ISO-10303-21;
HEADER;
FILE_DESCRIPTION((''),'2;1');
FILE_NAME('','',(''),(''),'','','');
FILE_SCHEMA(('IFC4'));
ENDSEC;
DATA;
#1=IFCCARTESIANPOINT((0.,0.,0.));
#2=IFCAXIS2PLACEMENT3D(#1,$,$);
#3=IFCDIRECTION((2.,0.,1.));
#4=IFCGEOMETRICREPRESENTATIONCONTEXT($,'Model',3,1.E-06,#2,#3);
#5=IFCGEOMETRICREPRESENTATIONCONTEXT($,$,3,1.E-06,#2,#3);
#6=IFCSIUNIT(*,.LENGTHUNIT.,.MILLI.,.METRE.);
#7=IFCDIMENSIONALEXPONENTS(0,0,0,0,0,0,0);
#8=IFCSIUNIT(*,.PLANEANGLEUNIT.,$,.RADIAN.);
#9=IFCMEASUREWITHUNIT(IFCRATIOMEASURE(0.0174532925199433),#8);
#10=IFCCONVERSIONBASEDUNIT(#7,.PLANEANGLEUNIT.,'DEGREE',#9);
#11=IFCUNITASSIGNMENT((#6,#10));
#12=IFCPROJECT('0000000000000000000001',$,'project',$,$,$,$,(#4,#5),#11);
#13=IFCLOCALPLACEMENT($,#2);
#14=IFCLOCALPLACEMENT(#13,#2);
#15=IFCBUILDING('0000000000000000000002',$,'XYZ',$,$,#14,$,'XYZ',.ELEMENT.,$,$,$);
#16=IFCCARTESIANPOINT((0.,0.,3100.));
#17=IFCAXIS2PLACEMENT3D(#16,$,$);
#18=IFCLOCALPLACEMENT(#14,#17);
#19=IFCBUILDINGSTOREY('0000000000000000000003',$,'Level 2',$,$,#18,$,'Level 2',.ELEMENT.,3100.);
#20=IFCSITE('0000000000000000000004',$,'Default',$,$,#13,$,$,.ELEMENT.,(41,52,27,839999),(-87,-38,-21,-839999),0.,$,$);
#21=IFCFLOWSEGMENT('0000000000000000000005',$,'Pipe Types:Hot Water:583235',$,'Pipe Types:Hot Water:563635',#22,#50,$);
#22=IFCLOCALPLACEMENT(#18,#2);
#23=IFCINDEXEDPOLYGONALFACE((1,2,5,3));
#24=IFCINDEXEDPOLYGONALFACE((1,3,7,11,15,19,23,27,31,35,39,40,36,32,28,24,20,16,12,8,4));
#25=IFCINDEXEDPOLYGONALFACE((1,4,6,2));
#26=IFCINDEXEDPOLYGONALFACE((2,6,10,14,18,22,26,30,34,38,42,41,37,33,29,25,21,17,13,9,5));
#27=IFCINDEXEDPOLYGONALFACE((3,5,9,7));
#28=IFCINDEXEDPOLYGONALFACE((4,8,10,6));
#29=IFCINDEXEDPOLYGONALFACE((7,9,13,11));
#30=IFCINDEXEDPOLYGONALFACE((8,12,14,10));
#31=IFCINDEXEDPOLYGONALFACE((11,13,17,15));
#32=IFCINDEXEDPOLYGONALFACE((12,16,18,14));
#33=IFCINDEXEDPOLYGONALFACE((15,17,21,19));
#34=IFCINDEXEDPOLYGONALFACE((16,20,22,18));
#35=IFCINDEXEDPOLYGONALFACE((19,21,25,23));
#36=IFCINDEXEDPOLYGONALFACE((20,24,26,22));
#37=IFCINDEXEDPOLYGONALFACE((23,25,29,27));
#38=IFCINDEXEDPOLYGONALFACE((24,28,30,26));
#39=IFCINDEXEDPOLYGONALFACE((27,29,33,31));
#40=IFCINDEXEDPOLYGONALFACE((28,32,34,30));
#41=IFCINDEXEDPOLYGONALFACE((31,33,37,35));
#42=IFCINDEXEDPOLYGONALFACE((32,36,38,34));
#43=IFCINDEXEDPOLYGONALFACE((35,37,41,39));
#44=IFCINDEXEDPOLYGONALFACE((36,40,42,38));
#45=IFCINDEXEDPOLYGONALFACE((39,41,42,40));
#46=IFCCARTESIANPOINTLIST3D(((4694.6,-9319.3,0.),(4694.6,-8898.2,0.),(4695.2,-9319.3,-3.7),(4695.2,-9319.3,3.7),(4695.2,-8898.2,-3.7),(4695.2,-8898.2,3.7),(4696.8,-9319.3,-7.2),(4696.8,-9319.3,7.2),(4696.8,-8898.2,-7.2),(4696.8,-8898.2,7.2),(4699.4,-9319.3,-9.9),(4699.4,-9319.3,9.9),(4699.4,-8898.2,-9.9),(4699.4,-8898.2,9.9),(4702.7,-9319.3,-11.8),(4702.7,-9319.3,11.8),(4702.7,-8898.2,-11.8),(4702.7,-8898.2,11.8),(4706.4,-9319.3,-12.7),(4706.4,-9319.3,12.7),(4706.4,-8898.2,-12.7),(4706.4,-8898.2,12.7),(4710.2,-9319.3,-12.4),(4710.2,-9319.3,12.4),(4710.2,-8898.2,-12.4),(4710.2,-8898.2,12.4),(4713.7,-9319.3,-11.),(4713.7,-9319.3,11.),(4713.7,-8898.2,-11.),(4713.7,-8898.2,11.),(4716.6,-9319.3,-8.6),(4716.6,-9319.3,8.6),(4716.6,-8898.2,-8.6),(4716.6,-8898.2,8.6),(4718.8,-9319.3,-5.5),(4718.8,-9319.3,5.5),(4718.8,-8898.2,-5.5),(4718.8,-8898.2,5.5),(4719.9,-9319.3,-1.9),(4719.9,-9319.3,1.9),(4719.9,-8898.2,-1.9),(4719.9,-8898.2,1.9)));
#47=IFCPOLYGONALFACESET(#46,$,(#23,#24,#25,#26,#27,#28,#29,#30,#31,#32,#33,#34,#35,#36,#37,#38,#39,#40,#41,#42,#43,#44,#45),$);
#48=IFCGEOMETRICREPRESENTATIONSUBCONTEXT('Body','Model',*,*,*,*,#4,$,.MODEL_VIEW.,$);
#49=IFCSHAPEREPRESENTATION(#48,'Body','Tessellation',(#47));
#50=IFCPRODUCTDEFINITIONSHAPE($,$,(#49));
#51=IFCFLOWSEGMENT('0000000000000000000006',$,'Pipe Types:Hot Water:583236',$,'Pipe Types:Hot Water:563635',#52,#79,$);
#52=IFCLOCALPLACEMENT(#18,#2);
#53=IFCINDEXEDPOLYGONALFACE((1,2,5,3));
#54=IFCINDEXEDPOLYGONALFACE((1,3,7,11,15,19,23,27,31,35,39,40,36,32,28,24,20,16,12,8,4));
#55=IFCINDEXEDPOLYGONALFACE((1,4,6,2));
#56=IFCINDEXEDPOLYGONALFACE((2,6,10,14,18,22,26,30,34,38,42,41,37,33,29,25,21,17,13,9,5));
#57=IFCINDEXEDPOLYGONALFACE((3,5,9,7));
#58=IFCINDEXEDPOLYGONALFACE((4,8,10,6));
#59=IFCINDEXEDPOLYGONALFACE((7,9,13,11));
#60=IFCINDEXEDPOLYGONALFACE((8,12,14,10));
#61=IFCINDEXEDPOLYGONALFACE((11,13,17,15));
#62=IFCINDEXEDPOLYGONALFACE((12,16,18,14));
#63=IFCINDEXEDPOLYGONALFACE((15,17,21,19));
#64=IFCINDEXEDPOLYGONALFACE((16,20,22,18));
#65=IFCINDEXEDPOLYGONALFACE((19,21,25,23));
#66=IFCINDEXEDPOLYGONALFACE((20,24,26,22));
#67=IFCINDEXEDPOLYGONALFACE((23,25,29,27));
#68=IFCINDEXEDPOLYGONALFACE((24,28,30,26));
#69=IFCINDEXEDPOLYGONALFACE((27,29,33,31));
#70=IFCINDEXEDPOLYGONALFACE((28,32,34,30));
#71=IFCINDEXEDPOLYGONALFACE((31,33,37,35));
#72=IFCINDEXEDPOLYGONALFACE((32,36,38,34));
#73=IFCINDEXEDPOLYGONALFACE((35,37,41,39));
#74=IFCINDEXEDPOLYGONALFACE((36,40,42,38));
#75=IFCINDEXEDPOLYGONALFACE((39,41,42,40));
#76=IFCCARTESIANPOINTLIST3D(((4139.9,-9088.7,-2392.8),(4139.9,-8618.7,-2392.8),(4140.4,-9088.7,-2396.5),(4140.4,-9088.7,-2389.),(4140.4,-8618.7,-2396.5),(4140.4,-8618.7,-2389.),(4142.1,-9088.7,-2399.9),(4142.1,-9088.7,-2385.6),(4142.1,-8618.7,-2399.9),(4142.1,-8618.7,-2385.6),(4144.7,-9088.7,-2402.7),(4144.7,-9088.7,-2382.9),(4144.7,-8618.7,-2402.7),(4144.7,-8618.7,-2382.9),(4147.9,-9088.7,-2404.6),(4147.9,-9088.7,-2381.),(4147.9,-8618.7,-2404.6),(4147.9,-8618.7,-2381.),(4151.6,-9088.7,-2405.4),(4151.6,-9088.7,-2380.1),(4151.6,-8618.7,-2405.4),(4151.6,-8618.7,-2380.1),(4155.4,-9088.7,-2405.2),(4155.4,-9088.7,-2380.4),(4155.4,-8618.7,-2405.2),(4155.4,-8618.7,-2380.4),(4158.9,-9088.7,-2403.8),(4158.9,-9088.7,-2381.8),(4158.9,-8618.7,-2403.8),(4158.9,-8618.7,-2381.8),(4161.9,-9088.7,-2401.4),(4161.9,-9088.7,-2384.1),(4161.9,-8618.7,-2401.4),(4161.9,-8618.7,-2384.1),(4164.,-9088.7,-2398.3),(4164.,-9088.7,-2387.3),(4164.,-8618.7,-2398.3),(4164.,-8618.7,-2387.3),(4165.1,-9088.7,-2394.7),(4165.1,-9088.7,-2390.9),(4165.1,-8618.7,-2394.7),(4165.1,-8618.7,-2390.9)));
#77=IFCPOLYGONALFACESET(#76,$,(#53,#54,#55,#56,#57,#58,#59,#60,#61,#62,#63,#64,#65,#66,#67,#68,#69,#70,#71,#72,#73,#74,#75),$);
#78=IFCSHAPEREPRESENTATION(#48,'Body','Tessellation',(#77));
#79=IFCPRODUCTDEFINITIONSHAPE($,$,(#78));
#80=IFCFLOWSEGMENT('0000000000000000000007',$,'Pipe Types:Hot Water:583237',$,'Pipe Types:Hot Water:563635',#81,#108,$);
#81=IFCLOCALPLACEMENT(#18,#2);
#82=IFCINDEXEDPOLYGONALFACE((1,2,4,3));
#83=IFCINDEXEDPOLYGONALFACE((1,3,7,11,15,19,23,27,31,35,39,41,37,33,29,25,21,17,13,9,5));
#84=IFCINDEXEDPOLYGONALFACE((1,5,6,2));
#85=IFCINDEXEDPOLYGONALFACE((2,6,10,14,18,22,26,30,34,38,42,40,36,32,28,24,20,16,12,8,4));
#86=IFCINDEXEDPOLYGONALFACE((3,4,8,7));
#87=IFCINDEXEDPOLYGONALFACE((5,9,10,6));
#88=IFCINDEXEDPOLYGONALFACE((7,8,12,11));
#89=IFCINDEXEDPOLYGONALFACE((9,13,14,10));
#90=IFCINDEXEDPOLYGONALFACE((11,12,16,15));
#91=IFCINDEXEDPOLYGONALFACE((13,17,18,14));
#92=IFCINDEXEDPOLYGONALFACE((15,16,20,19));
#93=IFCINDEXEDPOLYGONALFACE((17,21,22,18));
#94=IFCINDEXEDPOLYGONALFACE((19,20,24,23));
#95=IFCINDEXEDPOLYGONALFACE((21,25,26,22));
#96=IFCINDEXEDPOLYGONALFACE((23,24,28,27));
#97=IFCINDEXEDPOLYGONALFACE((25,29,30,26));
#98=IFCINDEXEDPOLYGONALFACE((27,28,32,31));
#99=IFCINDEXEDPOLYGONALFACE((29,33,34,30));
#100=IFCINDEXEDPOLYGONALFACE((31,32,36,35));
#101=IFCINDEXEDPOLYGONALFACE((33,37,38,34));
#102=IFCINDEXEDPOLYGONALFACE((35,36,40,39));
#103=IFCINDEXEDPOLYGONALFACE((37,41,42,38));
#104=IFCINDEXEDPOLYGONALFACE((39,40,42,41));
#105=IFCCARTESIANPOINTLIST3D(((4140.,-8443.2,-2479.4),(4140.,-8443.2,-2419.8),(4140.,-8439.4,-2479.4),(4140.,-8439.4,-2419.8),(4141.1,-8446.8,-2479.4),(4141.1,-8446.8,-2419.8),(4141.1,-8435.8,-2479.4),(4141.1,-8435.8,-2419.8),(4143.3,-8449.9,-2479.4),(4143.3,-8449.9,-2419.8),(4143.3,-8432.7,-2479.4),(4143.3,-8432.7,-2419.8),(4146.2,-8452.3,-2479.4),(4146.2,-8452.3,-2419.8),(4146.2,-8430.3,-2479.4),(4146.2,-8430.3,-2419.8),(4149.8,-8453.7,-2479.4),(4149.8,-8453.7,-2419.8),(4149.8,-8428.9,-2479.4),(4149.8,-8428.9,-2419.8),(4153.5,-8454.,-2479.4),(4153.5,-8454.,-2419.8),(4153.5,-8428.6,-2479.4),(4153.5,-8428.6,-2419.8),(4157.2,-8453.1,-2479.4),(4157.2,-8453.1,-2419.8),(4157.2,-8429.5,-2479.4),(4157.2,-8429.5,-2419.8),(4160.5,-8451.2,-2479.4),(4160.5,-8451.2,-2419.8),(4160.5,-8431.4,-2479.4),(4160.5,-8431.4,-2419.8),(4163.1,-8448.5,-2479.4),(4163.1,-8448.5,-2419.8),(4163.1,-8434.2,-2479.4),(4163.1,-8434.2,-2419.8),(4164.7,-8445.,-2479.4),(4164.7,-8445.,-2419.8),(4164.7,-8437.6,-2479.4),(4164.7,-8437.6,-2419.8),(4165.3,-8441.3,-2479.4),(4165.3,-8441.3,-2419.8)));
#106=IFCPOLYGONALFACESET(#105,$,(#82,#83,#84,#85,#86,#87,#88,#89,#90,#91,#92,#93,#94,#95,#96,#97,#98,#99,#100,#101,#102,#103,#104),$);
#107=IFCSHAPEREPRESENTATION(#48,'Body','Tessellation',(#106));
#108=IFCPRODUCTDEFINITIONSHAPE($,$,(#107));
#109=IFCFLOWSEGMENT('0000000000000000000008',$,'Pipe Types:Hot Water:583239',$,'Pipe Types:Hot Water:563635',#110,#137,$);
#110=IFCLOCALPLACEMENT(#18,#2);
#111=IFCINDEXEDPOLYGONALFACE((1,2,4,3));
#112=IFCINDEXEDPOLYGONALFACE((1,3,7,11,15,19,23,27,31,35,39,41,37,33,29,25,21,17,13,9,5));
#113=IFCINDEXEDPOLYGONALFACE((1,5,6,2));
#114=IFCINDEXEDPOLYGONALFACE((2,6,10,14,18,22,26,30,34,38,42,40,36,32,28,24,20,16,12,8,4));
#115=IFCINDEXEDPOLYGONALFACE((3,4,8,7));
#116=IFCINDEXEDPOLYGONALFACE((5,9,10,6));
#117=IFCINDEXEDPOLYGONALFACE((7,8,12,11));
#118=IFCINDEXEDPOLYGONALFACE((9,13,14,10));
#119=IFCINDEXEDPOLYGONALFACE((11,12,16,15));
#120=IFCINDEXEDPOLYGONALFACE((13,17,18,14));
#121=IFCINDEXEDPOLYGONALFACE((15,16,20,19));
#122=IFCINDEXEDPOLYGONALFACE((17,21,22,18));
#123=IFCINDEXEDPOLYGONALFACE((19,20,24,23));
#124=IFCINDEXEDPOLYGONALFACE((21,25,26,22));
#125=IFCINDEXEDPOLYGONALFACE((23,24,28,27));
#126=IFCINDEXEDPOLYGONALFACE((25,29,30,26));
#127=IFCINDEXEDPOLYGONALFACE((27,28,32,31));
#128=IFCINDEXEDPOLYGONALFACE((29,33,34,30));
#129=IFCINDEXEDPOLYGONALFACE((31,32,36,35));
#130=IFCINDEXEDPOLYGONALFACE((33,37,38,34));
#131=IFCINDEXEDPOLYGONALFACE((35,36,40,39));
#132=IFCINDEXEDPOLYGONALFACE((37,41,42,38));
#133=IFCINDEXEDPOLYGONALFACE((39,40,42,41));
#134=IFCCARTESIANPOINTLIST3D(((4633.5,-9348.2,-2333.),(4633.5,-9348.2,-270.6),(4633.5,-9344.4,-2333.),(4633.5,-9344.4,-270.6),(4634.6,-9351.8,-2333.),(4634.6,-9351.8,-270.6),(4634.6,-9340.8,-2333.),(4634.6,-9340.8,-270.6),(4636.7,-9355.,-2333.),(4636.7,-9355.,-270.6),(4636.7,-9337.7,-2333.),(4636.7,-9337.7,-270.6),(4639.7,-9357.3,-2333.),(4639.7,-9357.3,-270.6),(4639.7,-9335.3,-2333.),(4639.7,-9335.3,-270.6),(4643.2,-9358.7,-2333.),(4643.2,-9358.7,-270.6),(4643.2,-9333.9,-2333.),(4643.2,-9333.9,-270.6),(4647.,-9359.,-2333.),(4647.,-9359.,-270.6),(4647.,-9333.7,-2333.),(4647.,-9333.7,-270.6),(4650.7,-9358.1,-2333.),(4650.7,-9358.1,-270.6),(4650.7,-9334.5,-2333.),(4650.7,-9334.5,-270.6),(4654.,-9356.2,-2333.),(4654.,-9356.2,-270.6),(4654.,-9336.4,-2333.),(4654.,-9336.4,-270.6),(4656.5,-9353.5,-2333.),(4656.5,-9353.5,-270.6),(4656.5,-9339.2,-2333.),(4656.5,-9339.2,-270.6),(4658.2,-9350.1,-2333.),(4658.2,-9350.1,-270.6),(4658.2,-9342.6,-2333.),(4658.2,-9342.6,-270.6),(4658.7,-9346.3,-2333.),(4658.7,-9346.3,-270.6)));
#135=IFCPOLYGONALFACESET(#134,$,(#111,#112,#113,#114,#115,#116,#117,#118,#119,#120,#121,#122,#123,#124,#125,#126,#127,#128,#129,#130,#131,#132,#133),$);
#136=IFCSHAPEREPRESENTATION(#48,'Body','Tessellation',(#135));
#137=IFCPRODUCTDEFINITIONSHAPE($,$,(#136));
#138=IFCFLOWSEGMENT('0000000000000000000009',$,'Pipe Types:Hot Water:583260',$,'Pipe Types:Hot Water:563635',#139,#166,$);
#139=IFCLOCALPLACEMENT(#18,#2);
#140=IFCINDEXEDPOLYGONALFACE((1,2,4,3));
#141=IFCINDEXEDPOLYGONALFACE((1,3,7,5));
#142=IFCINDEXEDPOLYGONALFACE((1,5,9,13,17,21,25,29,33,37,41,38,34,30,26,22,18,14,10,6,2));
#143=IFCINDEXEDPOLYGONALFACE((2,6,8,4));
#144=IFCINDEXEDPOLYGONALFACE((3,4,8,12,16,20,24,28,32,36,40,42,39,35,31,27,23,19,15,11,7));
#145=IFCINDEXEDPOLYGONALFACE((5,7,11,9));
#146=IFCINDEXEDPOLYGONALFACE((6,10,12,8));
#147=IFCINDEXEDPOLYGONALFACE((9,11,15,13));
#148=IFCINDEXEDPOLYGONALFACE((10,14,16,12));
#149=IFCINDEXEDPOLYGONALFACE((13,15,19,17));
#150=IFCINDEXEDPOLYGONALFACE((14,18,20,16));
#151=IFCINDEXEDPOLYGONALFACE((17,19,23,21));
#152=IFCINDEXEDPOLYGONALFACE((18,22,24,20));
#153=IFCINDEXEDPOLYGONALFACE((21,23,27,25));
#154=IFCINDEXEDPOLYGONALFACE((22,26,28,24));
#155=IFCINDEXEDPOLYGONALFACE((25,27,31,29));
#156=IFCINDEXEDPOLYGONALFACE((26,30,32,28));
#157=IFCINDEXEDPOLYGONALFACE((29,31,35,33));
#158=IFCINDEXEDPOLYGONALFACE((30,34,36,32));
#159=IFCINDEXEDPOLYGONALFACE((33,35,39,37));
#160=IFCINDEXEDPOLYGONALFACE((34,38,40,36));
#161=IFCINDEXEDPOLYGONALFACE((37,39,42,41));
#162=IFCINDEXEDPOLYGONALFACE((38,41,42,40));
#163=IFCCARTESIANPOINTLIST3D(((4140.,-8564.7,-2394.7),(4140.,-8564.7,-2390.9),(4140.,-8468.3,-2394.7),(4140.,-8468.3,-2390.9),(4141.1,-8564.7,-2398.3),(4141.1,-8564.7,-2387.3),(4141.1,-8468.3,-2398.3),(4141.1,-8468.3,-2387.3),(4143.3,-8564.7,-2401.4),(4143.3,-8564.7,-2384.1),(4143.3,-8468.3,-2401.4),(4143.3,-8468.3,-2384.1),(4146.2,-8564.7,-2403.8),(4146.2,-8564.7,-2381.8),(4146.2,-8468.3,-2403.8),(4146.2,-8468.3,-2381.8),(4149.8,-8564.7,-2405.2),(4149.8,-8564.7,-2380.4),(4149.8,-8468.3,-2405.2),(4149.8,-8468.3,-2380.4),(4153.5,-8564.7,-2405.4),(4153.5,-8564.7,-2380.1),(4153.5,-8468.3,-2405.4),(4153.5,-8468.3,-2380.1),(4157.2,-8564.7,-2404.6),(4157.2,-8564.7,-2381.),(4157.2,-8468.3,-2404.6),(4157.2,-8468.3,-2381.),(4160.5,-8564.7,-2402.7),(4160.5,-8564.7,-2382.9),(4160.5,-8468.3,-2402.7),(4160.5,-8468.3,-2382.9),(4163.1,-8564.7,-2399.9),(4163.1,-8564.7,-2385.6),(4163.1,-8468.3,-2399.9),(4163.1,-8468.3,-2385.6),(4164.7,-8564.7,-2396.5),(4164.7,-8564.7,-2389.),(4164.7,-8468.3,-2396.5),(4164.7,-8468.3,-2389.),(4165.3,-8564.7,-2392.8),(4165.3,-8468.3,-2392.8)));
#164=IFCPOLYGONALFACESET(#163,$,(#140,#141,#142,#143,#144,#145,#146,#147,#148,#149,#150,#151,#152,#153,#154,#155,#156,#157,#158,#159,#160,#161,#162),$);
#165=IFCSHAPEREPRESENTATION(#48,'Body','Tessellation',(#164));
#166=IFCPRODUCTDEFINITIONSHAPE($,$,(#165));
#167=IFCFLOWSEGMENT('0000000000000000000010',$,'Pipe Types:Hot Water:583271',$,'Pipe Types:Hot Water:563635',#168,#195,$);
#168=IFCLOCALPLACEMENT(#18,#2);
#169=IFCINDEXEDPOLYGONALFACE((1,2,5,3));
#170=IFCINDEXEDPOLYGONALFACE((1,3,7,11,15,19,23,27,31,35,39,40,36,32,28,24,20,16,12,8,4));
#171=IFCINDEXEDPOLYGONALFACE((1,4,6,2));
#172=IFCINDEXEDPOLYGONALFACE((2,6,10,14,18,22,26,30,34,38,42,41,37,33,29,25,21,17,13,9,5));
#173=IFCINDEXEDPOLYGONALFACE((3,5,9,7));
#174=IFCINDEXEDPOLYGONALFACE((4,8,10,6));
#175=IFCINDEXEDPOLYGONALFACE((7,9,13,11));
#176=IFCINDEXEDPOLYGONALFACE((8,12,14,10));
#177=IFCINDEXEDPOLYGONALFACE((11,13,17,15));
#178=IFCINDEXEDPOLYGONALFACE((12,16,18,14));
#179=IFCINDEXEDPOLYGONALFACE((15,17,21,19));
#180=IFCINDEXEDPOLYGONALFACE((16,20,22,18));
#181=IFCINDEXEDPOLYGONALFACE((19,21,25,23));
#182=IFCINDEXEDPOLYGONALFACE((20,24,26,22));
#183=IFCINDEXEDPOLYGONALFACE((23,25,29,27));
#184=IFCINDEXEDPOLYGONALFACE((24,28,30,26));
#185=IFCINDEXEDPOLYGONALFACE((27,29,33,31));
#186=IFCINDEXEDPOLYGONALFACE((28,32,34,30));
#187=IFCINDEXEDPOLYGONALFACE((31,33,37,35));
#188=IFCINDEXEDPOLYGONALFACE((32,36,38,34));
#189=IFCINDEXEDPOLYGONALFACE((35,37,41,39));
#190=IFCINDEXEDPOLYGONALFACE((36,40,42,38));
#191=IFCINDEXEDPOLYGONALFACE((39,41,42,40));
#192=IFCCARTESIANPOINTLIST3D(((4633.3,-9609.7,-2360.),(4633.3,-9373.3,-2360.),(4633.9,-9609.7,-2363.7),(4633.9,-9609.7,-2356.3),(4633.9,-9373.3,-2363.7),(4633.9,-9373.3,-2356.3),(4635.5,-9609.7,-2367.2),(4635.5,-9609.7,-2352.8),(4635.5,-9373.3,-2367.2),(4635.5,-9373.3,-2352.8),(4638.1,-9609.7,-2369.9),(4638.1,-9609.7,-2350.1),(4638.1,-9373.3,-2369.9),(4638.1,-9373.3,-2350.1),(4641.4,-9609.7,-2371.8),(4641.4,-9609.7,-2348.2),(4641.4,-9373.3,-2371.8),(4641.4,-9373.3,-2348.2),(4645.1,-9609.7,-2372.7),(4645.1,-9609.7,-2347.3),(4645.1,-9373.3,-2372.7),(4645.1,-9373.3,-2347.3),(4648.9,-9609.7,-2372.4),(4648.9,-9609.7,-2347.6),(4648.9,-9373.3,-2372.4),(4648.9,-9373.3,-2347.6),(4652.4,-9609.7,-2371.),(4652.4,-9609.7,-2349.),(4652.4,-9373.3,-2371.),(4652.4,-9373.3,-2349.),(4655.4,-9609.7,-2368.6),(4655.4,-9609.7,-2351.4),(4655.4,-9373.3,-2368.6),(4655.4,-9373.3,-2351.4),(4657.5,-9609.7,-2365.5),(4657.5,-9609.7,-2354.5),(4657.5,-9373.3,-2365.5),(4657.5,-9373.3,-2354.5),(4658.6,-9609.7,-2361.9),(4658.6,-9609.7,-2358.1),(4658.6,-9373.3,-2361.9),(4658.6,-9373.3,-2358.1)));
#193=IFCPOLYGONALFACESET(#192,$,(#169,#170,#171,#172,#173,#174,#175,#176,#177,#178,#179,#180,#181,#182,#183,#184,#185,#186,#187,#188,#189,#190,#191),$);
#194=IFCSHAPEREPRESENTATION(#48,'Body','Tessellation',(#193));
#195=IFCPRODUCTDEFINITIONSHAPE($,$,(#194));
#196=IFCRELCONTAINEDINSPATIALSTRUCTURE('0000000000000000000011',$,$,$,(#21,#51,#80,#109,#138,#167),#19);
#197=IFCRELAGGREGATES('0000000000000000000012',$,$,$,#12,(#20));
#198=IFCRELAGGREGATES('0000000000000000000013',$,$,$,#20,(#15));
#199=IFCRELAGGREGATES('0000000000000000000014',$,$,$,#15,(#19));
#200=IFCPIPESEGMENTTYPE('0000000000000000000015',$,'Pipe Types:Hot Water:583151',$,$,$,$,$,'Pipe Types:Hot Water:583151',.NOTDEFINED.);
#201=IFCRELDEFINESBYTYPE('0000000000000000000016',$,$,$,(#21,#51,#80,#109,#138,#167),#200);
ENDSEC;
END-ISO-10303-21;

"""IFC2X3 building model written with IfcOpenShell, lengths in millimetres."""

from ifc_helpers import new_model, entity, si_unit, converted_unit, direction, frame, frame_2d, origin, origin_2d_with_axis, place, context, subcontext, project, spatial, circle, extrude, type_object, element, save


model = new_model("IFC2X3")

# Units and contexts
model_context = context("Model", 3, precision=1e-06, world=origin(), true_north=direction((2.0, 0.0, 1.0)))
context_of_model = context(None, 3, precision=1e-06, world=origin(), true_north=direction((2.0, 0.0, 1.0)))
body_context = subcontext(model_context, "Body", "Model", "MODEL_VIEW")
ifc_project = project(units=[si_unit("LENGTHUNIT", "METRE", prefix="MILLI"), converted_unit("PLANEANGLEUNIT", "DEGREE", entity("IfcRatioMeasure", 0.0174532925199433), si_unit("PLANEANGLEUNIT", "RADIAN"), dimensions=[0, 0, 0, 0, 0, 0, 0])], contexts=[model_context, context_of_model])

# Site, building, storey
site_placement = place(None, origin())
site = spatial("IfcSite", under=ifc_project, at=site_placement, Name="Default", CompositionType="ELEMENT", RefLatitude=(41, 52, 27, 839999), RefLongitude=(-87, -38, -21, -839999), RefElevation=0.0)
building_placement = place(site_placement, origin())
building = spatial("IfcBuilding", under=site, at=building_placement, Name="XYZ", LongName="XYZ", CompositionType="ELEMENT")
storey_placement = place(building_placement, frame((0.0, 0.0, 3100.0)))
storey = spatial("IfcBuildingStorey", under=building, at=storey_placement, Name="Level 2", LongName="Level 2", CompositionType="ELEMENT", Elevation=3100.0)

# Flow segments
pipe_segment_type_1 = type_object("IfcPipeSegmentType", Name="Pipe Types:Hot Water:583151", ElementType="Pipe Types:Hot Water:583151", PredefinedType="NOTDEFINED")
flow_segment_1_placement = place(storey_placement, origin())
element("IfcFlowSegment", 1, at=flow_segment_1_placement, inside=storey, type_object=pipe_segment_type_1, Name="Pipe Types:Hot Water:583235", ObjectType="Pipe Types:Hot Water:563635", context=body_context, shape_type="SweptSolid", body=[
    extrude(circle(Radius=12.7, at=frame_2d((0.0, 0.0), x_axis=(1.0, 0.0))), frame((4707.3, -9319.3, 0.0), z_axis=(0.0, 1.0, 0.0), x_axis=(-1.0, 0.0, 0.0)), (0.0, 0.0, 1.0), 421.2),
])
flow_segment_2_placement = place(storey_placement, origin())
element("IfcFlowSegment", 2, at=flow_segment_2_placement, inside=storey, type_object=pipe_segment_type_1, Name="Pipe Types:Hot Water:583236", ObjectType="Pipe Types:Hot Water:563635", context=body_context, shape_type="SweptSolid", body=[
    extrude(circle(Radius=12.7, at=frame_2d((0.0, 0.0), x_axis=(1.0, 0.0))), frame((4152.6, -9088.7, -2392.8), z_axis=(0.0, 1.0, 0.0), x_axis=(-1.0, 0.0, 0.0)), (0.0, 0.0, 1.0), 470.0),
])
flow_segment_3_placement = place(storey_placement, origin())
element("IfcFlowSegment", 3, at=flow_segment_3_placement, inside=storey, type_object=pipe_segment_type_1, Name="Pipe Types:Hot Water:583237", ObjectType="Pipe Types:Hot Water:563635", context=body_context, shape_type="SweptSolid", body=[
    extrude(circle(Radius=12.7, at=origin_2d_with_axis()), frame((4152.6, -8441.3, -2479.4)), (0.0, 0.0, 1.0), 59.6),
])
flow_segment_4_placement = place(storey_placement, origin())
element("IfcFlowSegment", 4, at=flow_segment_4_placement, inside=storey, type_object=pipe_segment_type_1, Name="Pipe Types:Hot Water:583239", ObjectType="Pipe Types:Hot Water:563635", context=body_context, shape_type="SweptSolid", body=[
    extrude(circle(Radius=12.7, at=origin_2d_with_axis()), frame((4646.0, -9346.3, -2333.0)), (0.0, 0.0, 1.0), 2062.4),
])
flow_segment_5_placement = place(storey_placement, origin())
element("IfcFlowSegment", 5, at=flow_segment_5_placement, inside=storey, type_object=pipe_segment_type_1, Name="Pipe Types:Hot Water:583260", ObjectType="Pipe Types:Hot Water:563635", context=body_context, shape_type="SweptSolid", body=[
    extrude(circle(Radius=12.7, at=origin_2d_with_axis()), frame((4152.6, -8564.7, -2392.8), z_axis=(0.0, 1.0, 0.0), x_axis=(1.0, 0.0, 0.0)), (0.0, 0.0, 1.0), 96.4),
])
flow_segment_6_placement = place(storey_placement, origin())
element("IfcFlowSegment", 6, at=flow_segment_6_placement, inside=storey, type_object=pipe_segment_type_1, Name="Pipe Types:Hot Water:583271", ObjectType="Pipe Types:Hot Water:563635", context=body_context, shape_type="SweptSolid", body=[
    extrude(circle(Radius=12.7, at=frame_2d((0.0, 0.0), x_axis=(1.0, 0.0))), frame((4646.0, -9609.7, -2360.0), z_axis=(0.0, 1.0, 0.0), x_axis=(-1.0, 0.0, 0.0)), (0.0, 0.0, 1.0), 236.3),
])

save(model, "model.ifc")
